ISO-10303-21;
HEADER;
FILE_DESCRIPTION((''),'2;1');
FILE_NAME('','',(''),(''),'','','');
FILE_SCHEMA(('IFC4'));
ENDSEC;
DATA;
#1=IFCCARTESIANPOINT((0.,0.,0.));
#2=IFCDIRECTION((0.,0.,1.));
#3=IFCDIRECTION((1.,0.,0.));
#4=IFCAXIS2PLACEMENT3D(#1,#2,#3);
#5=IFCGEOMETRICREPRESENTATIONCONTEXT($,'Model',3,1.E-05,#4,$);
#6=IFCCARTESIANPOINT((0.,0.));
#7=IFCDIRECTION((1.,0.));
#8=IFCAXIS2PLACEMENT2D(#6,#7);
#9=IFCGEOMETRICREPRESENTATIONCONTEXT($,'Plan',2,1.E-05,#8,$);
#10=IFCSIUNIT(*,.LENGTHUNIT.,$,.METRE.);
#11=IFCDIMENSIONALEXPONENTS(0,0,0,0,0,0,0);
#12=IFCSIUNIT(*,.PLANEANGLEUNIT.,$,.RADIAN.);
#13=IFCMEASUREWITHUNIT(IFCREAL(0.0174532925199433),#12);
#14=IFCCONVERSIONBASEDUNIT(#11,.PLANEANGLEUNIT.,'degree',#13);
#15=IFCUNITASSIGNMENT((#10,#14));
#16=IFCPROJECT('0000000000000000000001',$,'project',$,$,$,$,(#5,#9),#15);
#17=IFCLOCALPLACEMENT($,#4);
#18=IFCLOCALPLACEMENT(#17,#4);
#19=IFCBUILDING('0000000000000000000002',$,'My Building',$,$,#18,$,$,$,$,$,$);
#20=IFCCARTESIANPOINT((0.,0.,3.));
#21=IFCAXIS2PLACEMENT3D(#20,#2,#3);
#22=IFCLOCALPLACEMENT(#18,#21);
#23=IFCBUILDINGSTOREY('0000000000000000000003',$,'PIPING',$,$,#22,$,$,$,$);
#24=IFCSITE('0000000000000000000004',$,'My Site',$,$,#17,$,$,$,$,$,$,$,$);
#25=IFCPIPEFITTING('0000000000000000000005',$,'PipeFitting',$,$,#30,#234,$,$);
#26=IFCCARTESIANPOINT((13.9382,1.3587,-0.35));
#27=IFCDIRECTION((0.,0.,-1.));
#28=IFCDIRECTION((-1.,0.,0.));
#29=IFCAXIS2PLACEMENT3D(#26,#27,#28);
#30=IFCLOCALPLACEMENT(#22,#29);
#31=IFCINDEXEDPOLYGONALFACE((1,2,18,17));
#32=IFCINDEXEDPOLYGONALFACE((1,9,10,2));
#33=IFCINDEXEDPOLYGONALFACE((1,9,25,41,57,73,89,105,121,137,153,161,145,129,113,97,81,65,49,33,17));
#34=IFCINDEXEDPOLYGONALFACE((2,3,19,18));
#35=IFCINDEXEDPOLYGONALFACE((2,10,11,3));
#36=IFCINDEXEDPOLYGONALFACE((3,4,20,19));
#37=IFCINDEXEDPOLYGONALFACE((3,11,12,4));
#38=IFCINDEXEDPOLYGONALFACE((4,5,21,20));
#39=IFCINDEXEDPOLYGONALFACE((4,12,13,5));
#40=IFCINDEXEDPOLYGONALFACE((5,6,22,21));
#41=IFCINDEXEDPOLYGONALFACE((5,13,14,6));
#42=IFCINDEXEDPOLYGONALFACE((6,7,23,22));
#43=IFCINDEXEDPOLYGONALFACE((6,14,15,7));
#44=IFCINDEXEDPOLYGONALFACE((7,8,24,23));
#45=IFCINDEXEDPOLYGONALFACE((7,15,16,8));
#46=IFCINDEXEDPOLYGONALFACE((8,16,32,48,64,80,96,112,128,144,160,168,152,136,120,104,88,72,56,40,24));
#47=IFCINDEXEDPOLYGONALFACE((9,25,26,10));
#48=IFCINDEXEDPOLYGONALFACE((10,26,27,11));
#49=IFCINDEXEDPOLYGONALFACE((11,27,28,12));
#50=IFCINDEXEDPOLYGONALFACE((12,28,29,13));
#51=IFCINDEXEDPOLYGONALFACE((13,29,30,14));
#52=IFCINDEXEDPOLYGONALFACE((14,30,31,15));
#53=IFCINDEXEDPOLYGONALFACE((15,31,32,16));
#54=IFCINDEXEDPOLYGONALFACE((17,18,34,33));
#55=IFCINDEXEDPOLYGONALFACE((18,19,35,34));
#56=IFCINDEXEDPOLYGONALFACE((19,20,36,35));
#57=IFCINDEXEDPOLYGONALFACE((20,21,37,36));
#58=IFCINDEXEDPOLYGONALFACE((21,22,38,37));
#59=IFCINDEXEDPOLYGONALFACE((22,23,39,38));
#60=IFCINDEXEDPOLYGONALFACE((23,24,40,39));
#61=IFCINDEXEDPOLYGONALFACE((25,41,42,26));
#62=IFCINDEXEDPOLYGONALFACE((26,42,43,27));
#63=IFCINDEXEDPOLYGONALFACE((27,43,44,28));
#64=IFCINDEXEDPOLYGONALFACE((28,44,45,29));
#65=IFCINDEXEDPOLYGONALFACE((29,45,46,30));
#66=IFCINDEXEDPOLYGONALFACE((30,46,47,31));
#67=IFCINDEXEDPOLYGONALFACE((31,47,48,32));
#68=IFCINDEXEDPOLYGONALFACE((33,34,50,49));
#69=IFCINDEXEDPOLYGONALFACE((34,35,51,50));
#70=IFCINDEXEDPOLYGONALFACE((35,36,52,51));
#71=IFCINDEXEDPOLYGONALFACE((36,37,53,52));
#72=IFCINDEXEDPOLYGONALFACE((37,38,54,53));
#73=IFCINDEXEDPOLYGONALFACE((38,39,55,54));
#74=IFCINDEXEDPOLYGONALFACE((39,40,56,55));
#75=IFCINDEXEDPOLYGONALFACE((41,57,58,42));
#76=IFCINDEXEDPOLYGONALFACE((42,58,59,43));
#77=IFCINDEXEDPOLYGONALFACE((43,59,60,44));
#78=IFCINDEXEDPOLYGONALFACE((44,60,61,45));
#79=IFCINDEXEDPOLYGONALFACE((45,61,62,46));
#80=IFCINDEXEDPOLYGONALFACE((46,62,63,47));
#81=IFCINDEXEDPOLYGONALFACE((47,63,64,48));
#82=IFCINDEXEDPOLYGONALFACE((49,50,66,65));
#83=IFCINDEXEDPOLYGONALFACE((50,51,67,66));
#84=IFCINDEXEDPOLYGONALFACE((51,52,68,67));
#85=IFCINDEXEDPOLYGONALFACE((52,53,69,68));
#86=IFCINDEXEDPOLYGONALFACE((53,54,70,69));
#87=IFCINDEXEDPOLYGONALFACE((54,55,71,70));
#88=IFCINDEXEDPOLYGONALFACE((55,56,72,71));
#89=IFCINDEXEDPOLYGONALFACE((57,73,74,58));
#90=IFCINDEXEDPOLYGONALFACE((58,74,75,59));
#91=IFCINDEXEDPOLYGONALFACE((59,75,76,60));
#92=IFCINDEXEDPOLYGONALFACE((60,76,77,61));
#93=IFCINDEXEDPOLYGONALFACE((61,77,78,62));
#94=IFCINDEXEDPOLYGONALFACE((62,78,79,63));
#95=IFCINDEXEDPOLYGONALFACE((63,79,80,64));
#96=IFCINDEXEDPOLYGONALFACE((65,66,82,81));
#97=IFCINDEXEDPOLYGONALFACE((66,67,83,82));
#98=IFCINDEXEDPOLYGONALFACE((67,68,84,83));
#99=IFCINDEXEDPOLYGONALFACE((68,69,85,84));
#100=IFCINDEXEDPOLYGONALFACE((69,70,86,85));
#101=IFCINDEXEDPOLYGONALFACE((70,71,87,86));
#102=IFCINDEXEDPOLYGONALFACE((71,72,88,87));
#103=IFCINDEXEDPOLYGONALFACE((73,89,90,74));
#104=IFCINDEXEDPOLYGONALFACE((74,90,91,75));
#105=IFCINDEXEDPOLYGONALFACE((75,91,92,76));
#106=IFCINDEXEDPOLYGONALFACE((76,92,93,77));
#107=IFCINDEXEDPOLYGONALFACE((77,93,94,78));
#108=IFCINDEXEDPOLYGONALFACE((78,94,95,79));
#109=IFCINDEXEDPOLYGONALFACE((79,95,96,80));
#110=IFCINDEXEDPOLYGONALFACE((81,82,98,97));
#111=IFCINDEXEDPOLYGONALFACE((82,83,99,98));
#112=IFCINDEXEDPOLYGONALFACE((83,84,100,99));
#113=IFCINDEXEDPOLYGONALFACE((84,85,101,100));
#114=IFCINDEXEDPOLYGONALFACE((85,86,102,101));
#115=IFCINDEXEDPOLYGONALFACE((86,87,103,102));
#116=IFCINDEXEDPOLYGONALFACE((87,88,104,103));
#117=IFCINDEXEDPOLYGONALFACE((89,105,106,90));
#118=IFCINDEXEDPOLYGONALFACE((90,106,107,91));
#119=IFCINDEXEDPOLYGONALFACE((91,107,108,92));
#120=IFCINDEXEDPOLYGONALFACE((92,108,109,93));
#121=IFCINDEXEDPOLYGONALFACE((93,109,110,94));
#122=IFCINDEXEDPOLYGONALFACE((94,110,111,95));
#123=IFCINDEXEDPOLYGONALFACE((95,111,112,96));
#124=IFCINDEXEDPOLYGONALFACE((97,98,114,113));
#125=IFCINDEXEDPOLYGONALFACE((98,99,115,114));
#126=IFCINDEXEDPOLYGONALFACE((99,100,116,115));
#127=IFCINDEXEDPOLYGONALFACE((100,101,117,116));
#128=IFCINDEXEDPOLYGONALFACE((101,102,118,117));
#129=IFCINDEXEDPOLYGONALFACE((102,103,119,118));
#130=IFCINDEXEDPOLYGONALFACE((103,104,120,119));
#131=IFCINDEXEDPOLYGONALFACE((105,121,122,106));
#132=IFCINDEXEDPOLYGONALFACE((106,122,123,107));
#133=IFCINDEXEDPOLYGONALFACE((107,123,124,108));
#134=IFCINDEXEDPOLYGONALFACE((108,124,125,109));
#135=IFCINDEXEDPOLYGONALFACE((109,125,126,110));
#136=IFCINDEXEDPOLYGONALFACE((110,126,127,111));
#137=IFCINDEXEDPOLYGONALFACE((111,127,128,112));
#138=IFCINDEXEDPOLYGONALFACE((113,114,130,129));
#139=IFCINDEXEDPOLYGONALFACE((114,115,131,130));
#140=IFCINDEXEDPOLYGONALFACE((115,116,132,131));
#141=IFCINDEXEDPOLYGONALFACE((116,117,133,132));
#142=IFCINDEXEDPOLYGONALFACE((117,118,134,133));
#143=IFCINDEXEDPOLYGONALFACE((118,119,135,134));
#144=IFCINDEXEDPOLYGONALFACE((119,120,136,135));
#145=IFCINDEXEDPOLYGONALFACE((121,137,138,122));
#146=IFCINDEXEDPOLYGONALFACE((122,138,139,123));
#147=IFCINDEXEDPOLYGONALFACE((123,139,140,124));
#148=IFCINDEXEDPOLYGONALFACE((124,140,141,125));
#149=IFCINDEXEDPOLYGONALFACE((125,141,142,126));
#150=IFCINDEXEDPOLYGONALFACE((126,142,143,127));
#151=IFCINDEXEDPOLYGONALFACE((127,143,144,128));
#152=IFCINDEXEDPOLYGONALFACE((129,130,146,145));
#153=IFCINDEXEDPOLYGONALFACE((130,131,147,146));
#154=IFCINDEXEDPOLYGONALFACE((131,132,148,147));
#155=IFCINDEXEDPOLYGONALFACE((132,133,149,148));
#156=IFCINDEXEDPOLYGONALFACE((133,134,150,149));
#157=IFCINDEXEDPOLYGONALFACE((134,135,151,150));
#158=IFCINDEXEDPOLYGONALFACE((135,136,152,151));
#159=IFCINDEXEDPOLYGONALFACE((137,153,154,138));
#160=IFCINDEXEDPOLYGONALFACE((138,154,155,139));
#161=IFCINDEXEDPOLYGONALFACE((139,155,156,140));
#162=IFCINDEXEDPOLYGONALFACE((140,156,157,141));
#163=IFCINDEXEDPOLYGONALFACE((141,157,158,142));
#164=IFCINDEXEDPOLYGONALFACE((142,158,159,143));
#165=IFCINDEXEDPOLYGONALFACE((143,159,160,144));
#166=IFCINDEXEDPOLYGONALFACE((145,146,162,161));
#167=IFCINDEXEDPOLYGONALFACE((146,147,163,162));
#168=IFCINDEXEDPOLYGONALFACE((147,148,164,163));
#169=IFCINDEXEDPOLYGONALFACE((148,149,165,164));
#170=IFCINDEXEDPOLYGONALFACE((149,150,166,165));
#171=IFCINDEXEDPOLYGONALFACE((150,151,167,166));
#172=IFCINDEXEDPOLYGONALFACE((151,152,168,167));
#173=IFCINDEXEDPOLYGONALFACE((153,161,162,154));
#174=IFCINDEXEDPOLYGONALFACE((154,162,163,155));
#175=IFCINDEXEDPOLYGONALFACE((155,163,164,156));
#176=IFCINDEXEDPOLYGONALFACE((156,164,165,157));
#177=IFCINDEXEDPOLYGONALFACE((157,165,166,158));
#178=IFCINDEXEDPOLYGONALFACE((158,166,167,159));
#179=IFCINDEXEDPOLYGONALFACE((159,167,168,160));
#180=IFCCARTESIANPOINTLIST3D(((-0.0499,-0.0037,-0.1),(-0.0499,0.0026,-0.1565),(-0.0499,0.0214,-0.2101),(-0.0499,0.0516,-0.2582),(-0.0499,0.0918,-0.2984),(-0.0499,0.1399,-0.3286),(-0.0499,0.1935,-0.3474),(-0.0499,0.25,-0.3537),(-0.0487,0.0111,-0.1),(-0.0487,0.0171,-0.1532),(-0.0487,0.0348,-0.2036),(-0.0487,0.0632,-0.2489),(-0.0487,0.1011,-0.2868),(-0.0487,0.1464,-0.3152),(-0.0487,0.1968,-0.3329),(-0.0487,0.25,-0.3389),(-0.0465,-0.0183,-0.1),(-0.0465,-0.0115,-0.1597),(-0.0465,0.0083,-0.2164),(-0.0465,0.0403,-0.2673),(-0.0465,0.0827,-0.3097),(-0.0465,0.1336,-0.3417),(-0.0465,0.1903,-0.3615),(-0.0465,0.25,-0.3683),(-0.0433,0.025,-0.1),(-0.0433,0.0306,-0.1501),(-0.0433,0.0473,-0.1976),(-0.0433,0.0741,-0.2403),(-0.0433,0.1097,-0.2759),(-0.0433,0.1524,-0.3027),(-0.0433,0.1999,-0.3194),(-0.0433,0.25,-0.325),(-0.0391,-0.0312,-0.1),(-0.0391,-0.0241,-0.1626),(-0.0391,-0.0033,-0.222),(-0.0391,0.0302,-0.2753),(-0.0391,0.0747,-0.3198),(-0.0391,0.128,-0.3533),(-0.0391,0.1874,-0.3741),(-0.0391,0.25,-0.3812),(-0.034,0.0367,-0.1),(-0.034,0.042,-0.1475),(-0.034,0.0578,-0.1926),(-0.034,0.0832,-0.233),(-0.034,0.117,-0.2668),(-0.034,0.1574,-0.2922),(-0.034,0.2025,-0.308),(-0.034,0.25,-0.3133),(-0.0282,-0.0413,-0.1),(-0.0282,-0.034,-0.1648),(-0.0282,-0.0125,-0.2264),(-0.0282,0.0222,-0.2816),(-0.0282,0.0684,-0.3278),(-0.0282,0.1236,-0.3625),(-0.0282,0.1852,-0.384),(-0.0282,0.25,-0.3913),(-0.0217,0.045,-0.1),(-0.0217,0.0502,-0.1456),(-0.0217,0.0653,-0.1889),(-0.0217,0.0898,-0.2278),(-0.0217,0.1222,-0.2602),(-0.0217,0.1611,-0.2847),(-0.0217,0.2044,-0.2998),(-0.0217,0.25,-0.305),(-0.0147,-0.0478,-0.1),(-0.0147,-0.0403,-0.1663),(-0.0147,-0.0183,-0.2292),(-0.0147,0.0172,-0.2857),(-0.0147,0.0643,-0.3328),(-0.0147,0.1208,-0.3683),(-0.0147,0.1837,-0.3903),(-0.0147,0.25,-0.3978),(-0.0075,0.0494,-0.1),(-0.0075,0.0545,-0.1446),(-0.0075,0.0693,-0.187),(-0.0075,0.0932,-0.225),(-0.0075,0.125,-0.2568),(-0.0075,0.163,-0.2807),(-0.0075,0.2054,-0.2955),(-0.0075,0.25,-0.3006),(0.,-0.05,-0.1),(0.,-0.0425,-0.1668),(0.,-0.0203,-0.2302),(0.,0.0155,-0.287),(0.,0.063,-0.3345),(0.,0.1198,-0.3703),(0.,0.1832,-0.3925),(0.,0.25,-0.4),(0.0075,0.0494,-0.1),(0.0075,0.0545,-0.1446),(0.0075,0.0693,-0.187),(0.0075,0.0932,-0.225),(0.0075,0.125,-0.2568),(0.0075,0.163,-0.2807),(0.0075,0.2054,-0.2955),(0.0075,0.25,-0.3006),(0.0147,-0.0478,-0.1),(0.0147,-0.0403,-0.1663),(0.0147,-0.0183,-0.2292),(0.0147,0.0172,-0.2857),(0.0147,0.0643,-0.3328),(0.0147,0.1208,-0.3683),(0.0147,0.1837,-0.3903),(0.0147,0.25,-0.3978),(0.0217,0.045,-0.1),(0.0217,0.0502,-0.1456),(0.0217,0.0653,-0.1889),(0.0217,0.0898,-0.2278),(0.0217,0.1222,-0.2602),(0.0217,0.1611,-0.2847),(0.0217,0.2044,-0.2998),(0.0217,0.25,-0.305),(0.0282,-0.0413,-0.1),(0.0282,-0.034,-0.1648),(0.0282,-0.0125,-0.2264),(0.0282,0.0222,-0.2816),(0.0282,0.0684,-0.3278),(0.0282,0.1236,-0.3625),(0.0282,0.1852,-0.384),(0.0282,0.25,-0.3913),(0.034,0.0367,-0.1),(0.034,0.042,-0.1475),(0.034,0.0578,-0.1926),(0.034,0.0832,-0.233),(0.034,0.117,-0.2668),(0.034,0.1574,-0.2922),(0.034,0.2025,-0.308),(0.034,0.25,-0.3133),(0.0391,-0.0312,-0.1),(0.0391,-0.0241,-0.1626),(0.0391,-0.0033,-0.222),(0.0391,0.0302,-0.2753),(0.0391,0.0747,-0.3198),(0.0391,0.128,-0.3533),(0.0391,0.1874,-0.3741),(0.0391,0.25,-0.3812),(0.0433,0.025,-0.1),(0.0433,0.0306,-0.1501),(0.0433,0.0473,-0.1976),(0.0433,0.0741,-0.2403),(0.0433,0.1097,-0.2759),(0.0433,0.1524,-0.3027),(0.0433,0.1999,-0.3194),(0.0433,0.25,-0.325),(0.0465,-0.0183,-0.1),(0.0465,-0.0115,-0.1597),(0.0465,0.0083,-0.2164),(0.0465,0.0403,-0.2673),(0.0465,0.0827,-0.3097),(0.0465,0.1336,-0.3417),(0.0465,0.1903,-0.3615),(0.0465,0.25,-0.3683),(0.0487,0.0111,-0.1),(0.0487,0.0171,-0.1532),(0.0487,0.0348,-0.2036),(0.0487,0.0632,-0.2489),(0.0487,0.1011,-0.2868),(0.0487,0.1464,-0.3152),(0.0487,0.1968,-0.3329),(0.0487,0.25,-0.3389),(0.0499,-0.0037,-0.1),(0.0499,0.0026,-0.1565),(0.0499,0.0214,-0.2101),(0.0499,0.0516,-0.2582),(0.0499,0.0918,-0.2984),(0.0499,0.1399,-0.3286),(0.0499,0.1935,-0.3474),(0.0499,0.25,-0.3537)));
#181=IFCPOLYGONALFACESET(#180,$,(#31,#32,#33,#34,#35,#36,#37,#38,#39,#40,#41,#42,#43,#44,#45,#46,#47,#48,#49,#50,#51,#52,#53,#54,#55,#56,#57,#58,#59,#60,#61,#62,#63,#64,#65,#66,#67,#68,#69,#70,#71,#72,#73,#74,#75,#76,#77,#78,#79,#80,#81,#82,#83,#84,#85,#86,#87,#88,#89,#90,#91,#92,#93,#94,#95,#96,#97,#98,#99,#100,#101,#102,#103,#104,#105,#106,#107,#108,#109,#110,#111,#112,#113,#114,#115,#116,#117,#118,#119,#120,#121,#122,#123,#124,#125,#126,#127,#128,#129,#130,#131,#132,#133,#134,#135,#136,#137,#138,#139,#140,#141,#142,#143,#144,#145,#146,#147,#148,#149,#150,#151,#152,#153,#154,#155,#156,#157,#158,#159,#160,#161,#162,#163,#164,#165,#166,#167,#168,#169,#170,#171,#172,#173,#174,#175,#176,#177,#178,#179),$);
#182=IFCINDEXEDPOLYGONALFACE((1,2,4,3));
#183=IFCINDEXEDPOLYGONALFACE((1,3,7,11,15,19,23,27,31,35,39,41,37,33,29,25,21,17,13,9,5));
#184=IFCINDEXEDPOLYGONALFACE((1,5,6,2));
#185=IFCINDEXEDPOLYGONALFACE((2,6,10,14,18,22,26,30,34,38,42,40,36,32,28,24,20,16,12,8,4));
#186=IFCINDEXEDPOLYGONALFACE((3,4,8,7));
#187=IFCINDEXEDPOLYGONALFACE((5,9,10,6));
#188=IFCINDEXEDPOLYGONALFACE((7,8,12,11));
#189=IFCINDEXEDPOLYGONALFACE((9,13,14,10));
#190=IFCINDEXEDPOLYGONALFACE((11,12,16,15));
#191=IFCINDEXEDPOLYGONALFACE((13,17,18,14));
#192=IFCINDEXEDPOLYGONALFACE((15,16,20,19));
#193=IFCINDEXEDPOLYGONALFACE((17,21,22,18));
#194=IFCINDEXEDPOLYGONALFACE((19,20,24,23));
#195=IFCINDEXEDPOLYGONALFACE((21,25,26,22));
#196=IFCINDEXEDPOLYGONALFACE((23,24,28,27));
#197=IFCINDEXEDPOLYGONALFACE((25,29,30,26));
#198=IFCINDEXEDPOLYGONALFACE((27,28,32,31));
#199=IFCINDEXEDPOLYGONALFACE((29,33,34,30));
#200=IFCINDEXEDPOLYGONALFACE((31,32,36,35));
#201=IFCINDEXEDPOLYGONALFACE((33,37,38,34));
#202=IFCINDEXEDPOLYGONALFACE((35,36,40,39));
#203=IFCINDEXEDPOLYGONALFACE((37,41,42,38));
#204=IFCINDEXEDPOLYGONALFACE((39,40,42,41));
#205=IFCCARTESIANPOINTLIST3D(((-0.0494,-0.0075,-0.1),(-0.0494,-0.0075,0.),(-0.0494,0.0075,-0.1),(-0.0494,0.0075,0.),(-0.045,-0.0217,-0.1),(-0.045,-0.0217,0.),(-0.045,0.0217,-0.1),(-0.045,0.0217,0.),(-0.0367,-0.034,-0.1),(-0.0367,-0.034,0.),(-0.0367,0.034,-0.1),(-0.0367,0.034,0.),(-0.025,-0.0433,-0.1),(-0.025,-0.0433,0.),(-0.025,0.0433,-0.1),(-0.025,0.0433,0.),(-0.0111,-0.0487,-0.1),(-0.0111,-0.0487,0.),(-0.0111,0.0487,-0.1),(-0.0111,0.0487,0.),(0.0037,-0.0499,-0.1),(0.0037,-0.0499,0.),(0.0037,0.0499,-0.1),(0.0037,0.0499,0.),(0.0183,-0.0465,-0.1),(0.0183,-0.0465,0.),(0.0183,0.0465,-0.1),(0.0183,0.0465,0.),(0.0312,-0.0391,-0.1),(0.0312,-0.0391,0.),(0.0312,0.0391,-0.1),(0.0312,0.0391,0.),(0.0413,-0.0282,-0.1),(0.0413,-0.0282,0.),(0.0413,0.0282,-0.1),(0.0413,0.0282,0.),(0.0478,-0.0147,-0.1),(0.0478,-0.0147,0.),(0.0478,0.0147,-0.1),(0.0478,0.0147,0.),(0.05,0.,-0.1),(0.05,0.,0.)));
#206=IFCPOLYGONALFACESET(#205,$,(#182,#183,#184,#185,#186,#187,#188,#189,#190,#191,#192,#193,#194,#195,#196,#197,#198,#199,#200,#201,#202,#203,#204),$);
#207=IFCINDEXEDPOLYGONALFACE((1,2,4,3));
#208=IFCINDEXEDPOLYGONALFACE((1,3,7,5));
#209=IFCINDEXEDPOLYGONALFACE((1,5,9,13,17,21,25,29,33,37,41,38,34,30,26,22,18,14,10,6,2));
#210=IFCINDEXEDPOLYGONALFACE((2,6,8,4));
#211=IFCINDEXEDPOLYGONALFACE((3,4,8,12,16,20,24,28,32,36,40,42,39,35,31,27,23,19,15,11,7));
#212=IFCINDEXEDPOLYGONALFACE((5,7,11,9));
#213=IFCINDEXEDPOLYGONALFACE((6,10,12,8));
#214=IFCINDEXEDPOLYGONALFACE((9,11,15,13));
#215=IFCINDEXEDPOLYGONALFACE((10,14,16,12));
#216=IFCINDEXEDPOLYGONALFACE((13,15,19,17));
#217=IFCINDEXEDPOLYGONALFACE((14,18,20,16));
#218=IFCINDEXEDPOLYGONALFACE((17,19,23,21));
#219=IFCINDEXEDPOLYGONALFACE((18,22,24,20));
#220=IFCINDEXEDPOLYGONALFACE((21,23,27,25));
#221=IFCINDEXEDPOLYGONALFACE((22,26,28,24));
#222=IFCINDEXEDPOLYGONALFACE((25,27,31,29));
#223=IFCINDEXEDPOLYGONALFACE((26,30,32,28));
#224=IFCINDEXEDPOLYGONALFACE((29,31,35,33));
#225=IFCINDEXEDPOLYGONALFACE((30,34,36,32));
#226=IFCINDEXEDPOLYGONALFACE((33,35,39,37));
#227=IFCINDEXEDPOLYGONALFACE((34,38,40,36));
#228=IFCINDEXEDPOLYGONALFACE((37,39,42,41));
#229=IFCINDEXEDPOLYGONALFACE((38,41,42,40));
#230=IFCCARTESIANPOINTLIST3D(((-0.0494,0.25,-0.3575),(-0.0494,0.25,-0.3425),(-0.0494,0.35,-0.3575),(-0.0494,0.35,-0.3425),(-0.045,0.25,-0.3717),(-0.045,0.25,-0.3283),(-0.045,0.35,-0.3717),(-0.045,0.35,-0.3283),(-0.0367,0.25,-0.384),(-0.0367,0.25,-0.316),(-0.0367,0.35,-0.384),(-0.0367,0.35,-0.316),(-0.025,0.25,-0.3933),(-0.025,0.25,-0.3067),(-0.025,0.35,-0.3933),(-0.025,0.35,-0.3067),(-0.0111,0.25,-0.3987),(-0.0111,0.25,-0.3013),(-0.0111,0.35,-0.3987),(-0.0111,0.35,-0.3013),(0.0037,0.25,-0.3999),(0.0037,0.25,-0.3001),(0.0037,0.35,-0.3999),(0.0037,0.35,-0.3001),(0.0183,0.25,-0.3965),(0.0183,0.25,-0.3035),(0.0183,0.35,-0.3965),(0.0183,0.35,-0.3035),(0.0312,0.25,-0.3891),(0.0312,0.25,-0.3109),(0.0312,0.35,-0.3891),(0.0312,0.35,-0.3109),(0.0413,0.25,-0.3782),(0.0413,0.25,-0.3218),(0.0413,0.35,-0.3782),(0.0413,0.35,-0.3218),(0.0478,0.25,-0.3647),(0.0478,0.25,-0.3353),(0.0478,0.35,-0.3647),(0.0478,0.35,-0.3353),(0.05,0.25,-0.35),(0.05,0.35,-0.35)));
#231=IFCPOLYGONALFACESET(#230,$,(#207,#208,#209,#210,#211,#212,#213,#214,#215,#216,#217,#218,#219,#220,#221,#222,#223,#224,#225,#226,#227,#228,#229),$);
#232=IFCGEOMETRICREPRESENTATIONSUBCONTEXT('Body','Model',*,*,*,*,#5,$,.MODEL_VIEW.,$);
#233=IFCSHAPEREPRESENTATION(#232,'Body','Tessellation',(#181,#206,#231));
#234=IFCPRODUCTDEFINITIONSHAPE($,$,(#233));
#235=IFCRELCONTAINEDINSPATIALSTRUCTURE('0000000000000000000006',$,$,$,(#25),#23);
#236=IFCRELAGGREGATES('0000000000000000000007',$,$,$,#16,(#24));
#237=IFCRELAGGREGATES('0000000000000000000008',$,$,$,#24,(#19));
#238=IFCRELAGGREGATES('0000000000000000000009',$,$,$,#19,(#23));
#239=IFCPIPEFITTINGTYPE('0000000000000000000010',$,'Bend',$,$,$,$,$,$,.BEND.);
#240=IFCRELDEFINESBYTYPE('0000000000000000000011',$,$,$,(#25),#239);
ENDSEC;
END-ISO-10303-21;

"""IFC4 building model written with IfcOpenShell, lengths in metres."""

from ifc_helpers import new_model, entity, si_unit, converted_unit, frame, origin_with_axes, origin_2d_with_axis, place, context, subcontext, project, spatial, line, indexed_curve, circle, outline, extrude, source, transform, mapped, type_object, type_shapes, element, save


model = new_model("IFC4")

# Units and contexts
model_context = context("Model", 3, precision=1e-05, world=origin_with_axes())
plan_context = context("Plan", 2, precision=1e-05, world=origin_2d_with_axis())
body_context = subcontext(model_context, "Body", "Model", "MODEL_VIEW")
ifc_project = project(units=[si_unit("LENGTHUNIT", "METRE"), converted_unit("PLANEANGLEUNIT", "degree", entity("IfcReal", 0.0174532925199433), si_unit("PLANEANGLEUNIT", "RADIAN"), dimensions=[0, 0, 0, 0, 0, 0, 0])], contexts=[model_context, plan_context])

# Site, building, storey
site_placement = place(None, origin_with_axes())
site = spatial("IfcSite", under=ifc_project, at=site_placement, Name="My Site")
building_placement = place(site_placement, origin_with_axes())
building = spatial("IfcBuilding", under=site, at=building_placement, Name="My Building")
storey_placement = place(building_placement, frame((0.0, 0.0, 3.0), z_axis=(0.0, 0.0, 1.0), x_axis=(1.0, 0.0, 0.0)))
storey = spatial("IfcBuildingStorey", under=building, at=storey_placement, Name="PIPING")

# Shared definitions
pipe_fitting_type_1 = type_object("IfcPipeFittingType", Name="Bend", PredefinedType="BEND")
shared_shape = source(origin_with_axes(), body_context, "Body", "SolidModel", [
    entity("IfcSweptDiskSolid", entity("IfcIndexedPolyCurve", entity("IfcCartesianPointList3D", [[0.0, 0.0, -0.1], [0.0, 0.0732, -0.2768], [0.0, 0.25, -0.35]]), [entity("IfcArcIndex", [1, 2, 3])]), 0.05),
    extrude(circle(Radius=0.05), origin_with_axes(), (0.0, 0.0, -1.0), 0.1),
    extrude(circle(Radius=0.05), frame((0.0, 0.25, -0.35), z_axis=(0.0, 1.0, 0.0), x_axis=(1.0, 0.0, 0.0)), (0.0, 0.0, 1.0), 0.1),
])
type_shapes(pipe_fitting_type_1, [shared_shape])

# Pipe fitting, opening
pipe_fitting_1_placement = place(storey_placement, frame((13.9382, 1.3587, -0.35), z_axis=(0.0, 0.0, -1.0), x_axis=(-1.0, 0.0, 0.0)))
pipe_fitting_1 = element("IfcPipeFitting", 1, at=pipe_fitting_1_placement, inside=storey, type_object=pipe_fitting_type_1, Name="PipeFitting", context=body_context, shape_type="MappedRepresentation", body=[
    mapped(shared_shape, transform((0.0, 0.0, 0.0), x_axis=(1.0, 0.0, 0.0), y_axis=(0.0, 1.0, 0.0), z_axis=(0.0, 0.0, 1.0), scale=1.0)),
])
opening_1_placement = place(pipe_fitting_1_placement, frame((13.9382, -1.3587, 2.65), z_axis=(0.0, 0.0, -1.0), x_axis=(-1.0, 0.0, 0.0)))
element("IfcOpeningElement", 2, at=opening_1_placement, cuts=pipe_fitting_1, PredefinedType="OPENING", context=body_context, shape_type="SweptSolid", body=[
    extrude(outline(indexed_curve([(0.0, 0.0), (0.5, 0.0), (0.5, 0.5), (0.0, 0.5)], segments=[line(1, 2, 3, 4, 1)])), origin_with_axes(), (0.0, 0.0, 1.0), 0.5),
])

save(model, "model.ifc")
